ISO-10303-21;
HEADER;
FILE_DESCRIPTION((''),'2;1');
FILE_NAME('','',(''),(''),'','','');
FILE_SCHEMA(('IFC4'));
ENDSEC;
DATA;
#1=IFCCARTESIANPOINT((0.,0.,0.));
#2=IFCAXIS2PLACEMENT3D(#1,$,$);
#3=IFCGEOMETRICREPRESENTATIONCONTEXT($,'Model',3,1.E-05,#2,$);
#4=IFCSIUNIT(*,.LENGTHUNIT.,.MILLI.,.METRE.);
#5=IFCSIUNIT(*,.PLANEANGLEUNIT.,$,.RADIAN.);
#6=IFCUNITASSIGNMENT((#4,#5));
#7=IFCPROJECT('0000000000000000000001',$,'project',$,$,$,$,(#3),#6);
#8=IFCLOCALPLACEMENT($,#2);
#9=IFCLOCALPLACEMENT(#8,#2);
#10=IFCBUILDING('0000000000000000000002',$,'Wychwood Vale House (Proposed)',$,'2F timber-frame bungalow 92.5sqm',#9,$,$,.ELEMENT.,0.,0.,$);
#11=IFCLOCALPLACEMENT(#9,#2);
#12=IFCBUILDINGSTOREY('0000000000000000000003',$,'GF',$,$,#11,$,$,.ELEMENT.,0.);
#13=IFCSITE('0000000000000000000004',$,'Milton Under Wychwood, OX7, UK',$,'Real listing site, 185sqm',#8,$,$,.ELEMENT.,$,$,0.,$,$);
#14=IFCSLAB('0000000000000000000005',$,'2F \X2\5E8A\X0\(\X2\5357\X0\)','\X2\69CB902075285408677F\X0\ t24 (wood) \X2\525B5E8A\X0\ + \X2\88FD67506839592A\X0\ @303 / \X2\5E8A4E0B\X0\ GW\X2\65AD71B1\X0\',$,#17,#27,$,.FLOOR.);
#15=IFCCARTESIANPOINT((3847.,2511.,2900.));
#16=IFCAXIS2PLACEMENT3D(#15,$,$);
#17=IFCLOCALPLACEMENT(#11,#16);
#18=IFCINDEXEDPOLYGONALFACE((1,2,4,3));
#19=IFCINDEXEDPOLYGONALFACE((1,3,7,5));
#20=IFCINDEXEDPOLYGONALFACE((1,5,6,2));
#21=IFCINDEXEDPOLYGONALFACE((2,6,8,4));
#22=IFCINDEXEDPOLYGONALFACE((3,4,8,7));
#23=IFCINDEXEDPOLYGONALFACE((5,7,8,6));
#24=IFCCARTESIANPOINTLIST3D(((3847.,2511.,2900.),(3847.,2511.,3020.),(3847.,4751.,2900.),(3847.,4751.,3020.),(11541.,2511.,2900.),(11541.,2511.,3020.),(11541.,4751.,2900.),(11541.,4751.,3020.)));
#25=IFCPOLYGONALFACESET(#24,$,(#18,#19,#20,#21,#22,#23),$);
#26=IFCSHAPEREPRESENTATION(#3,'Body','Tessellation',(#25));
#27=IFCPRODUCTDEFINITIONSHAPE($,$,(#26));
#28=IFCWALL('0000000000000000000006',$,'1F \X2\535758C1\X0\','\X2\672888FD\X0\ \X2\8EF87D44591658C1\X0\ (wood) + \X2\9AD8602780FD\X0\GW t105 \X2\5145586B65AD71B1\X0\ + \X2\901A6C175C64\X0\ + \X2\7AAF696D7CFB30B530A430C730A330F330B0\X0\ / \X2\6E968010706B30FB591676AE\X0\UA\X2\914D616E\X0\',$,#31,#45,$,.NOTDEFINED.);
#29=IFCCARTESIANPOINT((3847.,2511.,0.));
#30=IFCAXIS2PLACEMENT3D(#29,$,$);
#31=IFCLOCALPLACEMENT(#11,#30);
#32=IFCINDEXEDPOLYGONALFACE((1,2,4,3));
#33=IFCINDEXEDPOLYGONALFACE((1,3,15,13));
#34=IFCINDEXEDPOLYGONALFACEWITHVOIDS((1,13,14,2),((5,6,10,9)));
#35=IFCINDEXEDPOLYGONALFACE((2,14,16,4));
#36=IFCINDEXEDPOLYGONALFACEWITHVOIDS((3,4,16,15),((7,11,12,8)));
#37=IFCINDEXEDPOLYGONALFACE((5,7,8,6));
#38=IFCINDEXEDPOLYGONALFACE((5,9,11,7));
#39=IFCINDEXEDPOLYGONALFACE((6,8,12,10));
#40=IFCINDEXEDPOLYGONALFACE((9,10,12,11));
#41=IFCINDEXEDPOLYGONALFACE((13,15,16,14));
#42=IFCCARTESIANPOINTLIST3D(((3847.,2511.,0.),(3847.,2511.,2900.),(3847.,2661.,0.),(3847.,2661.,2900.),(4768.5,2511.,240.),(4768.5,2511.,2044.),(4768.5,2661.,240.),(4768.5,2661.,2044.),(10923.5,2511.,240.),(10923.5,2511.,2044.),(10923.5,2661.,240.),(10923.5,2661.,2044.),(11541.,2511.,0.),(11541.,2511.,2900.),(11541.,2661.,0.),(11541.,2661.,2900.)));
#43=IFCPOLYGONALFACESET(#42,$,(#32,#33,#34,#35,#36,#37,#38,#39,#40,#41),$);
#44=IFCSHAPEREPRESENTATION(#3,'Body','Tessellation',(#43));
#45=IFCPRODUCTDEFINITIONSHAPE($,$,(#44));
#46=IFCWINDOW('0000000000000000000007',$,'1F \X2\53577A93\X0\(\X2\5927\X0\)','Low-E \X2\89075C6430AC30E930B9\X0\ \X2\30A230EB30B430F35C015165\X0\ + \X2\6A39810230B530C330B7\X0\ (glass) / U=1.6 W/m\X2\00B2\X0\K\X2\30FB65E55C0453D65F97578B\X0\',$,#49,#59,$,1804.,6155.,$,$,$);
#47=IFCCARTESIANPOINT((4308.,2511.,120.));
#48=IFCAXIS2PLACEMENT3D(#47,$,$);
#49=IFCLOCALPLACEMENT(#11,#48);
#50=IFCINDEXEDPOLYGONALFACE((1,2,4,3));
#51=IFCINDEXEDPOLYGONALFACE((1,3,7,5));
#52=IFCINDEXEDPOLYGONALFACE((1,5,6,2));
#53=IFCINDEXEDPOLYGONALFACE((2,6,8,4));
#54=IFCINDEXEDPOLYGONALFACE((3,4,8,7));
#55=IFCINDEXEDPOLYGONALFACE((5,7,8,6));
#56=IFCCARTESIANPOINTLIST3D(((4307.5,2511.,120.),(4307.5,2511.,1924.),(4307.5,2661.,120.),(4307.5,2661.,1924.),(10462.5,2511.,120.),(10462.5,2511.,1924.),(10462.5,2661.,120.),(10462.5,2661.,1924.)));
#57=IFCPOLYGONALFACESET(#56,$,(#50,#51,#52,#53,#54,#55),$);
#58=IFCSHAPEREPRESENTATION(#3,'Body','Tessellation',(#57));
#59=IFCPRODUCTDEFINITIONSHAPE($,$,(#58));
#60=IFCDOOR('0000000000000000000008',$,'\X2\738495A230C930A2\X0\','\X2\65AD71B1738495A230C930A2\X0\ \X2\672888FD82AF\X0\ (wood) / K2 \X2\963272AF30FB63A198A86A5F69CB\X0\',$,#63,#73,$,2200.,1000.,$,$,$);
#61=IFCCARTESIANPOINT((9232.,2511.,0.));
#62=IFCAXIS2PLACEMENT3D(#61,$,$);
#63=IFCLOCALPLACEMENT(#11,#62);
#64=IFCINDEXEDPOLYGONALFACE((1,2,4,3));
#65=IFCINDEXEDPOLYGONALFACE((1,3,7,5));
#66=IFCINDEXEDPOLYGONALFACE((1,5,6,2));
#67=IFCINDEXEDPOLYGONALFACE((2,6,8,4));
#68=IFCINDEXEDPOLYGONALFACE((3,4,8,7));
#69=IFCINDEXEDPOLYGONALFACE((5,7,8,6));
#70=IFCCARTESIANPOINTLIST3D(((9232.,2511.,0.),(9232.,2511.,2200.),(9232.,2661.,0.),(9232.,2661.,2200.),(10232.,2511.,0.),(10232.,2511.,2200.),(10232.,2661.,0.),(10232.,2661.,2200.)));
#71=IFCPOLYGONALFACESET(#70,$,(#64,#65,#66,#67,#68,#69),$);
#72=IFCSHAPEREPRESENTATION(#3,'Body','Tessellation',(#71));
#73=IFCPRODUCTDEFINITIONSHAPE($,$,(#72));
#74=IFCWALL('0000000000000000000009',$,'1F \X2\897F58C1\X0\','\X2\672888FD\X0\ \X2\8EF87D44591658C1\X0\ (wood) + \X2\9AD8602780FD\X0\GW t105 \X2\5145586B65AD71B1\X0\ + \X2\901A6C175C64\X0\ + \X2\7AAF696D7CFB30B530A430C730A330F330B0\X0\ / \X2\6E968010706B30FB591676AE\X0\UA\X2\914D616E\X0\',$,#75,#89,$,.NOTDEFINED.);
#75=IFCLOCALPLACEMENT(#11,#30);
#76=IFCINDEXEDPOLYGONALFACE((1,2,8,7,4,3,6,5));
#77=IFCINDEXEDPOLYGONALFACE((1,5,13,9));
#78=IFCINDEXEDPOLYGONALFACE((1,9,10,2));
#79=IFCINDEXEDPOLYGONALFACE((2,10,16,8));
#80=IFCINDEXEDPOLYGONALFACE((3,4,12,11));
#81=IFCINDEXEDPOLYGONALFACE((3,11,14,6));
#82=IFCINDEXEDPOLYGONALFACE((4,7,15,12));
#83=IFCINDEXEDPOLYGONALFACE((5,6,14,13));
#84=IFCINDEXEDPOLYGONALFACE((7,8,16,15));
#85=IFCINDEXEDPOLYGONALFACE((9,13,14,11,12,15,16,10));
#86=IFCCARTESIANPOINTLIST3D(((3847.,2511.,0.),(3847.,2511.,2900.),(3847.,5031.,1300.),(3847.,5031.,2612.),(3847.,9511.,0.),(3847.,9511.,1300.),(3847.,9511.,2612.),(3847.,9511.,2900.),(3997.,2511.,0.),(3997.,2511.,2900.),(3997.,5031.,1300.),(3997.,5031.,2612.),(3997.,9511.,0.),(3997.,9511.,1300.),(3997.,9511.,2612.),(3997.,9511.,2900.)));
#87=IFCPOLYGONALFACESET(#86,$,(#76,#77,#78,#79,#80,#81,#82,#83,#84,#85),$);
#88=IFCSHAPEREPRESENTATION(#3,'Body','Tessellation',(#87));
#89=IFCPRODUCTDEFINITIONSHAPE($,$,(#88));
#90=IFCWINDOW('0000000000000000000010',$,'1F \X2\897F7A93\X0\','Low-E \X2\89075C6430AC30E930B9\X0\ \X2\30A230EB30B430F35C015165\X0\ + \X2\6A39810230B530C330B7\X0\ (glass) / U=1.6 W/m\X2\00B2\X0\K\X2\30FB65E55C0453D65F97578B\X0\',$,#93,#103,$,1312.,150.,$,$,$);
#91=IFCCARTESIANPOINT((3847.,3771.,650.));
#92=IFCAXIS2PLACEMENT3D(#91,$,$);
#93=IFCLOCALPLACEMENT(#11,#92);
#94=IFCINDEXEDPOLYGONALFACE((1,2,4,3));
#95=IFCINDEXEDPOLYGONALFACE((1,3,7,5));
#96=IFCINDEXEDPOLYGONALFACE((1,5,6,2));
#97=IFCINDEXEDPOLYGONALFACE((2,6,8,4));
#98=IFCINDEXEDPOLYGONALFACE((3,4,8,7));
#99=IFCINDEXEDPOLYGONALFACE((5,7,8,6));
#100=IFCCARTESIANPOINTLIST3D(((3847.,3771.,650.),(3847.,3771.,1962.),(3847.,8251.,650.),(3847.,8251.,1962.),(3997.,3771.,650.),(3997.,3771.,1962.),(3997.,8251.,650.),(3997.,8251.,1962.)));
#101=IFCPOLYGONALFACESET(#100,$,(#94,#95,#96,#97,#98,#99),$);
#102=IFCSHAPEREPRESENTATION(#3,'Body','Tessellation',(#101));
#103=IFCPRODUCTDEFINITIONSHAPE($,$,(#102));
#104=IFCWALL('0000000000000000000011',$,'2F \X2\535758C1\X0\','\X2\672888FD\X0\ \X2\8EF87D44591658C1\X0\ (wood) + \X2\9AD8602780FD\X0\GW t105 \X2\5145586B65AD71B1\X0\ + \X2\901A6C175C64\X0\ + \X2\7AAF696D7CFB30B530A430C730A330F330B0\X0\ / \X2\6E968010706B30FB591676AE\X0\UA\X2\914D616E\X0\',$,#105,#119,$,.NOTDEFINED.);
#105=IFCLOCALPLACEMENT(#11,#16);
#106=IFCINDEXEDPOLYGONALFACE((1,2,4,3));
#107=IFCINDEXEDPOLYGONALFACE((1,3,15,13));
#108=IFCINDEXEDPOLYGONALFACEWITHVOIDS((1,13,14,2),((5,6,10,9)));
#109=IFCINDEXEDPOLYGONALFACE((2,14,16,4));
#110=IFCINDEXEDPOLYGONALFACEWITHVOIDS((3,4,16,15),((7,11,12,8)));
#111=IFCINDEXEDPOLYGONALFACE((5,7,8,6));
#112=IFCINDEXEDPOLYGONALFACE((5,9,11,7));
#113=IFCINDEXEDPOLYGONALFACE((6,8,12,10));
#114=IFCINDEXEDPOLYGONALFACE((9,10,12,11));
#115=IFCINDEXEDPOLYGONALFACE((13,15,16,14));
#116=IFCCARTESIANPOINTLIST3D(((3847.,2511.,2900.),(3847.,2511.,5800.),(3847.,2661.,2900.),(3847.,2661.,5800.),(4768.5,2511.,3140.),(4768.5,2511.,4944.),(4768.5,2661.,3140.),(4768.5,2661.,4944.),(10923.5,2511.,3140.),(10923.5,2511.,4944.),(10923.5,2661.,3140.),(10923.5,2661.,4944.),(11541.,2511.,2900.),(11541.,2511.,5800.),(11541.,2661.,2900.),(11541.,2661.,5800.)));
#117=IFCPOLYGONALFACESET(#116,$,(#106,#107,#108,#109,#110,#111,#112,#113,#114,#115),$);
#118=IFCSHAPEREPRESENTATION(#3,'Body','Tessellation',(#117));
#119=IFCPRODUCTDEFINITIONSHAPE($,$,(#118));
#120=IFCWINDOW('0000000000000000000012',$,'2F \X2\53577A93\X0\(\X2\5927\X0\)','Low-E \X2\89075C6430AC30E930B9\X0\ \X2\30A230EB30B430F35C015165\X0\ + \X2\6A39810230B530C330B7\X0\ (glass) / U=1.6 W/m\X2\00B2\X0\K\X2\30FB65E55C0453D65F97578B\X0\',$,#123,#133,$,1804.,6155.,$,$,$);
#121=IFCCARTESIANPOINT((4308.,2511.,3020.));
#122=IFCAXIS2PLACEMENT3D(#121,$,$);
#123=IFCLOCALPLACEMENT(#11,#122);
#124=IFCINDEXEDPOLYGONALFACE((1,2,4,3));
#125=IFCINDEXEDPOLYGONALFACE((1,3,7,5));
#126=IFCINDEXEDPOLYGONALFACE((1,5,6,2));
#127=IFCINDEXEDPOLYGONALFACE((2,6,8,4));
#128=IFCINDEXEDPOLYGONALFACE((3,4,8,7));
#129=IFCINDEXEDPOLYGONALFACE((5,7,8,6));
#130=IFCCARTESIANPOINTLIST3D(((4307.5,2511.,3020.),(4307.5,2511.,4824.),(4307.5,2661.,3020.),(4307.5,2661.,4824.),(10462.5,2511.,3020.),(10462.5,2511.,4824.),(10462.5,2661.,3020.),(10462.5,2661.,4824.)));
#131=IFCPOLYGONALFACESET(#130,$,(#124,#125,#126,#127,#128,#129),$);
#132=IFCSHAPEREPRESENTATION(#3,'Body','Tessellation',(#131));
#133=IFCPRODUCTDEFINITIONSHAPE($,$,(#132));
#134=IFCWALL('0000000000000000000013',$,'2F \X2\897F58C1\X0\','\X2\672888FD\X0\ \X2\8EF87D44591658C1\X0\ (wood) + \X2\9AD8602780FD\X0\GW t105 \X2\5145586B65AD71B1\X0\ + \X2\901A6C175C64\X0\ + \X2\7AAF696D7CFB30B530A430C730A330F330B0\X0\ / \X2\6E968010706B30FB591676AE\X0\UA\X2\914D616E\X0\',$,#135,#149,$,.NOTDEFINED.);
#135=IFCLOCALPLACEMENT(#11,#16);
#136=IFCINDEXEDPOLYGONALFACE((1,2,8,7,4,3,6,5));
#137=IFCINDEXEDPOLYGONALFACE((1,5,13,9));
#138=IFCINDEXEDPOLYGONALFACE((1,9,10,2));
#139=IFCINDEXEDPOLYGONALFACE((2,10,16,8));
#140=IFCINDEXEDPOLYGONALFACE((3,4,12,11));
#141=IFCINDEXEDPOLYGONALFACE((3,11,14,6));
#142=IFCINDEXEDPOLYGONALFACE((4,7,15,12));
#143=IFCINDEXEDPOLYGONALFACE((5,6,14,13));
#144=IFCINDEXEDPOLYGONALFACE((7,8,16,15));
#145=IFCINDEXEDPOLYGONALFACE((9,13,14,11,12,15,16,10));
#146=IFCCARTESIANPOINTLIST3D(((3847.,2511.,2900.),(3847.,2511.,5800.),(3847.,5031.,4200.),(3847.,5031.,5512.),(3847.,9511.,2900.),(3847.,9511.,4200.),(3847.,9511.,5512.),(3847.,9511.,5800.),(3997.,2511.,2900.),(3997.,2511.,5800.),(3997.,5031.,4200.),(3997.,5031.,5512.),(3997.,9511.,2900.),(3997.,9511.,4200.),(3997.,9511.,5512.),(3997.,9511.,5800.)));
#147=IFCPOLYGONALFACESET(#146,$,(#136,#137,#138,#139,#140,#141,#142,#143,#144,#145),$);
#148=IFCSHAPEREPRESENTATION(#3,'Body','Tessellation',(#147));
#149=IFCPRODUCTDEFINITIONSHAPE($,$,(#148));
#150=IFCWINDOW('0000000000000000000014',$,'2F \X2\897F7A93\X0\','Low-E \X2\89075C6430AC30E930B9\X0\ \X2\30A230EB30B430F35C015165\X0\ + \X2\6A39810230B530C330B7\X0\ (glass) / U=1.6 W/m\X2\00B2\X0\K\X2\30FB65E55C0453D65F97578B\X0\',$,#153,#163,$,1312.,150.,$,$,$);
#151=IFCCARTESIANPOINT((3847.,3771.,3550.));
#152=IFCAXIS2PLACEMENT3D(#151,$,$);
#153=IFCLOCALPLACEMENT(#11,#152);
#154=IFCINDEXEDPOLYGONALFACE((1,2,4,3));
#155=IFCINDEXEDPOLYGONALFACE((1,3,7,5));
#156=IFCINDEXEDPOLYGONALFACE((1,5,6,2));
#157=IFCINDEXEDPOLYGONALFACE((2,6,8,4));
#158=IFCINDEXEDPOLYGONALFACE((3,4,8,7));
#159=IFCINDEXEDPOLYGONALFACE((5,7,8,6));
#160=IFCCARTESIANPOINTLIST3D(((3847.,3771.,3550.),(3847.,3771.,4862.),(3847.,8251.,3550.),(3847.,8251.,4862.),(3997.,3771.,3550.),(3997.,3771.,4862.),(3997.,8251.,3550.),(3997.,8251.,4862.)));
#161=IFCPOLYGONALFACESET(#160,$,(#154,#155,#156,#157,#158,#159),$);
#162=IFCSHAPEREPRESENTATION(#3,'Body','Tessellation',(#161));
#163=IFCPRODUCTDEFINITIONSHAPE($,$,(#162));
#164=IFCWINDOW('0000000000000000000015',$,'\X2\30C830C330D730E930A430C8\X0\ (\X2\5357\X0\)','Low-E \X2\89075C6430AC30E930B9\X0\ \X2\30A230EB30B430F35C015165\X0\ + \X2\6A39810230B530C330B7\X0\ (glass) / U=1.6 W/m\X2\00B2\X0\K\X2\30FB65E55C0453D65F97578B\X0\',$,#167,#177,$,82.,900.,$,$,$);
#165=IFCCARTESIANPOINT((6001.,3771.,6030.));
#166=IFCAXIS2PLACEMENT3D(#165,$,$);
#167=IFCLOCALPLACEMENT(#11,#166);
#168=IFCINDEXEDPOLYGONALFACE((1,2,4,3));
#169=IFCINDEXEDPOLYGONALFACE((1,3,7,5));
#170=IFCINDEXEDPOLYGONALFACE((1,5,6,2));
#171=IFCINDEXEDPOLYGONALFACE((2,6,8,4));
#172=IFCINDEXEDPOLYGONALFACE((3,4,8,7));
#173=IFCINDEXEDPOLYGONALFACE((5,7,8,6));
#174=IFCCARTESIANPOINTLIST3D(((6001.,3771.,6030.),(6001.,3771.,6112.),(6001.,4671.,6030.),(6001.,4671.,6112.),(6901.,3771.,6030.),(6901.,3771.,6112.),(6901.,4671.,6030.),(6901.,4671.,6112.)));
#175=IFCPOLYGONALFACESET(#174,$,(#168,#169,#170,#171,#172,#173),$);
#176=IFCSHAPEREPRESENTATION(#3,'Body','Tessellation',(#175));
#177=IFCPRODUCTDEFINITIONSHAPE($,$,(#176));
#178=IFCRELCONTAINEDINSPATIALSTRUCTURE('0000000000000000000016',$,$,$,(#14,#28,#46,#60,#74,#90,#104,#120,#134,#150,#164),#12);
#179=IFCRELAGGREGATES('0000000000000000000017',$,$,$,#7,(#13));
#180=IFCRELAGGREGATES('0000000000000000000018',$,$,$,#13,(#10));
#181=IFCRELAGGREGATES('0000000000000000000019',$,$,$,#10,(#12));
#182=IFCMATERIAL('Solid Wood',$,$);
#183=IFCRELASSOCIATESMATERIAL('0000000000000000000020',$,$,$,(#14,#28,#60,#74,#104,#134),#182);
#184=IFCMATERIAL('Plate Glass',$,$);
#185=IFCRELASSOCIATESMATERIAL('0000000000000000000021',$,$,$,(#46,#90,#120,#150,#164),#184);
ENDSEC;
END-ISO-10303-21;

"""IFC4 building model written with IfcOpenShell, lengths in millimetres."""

from ifc_helpers import new_model, si_unit, frame, frame_2d, origin, place, context, project, spatial, rectangle, extrude, material, element, fill, save


model = new_model("IFC4")

# Units and contexts
model_context = context("Model", 3, precision=1e-05, world=origin())
ifc_project = project(units=[si_unit("LENGTHUNIT", "METRE", prefix="MILLI"), si_unit("PLANEANGLEUNIT", "RADIAN")], contexts=[model_context])

# Site, building, storey
site_placement = place(None, origin())
site = spatial("IfcSite", under=ifc_project, at=site_placement, Name="Milton Under Wychwood, OX7, UK", ObjectType="Real listing site, 185sqm", CompositionType="ELEMENT", RefElevation=0.0)
building_placement = place(site_placement, origin())
building = spatial("IfcBuilding", under=site, at=building_placement, Name="Wychwood Vale House (Proposed)", ObjectType="2F timber-frame bungalow 92.5sqm", CompositionType="ELEMENT", ElevationOfRefHeight=0.0, ElevationOfTerrain=0.0)
storey_placement = place(building_placement, origin())
storey = spatial("IfcBuildingStorey", under=building, at=storey_placement, Name="GF", CompositionType="ELEMENT", Elevation=0.0)

# Slab
ifc_material_1 = material(Name="Solid Wood")
slab_1_placement = place(storey_placement, frame((3847.0, 2511.0, 2900.0)))
element("IfcSlab", 1, at=slab_1_placement, inside=storey, material=ifc_material_1, Name="2F 床(南)", Description="構造用合板 t24 (wood) 剛床 + 製材根太 @303 / 床下 GW断熱", PredefinedType="FLOOR", context=model_context, shape_type="SweptSolid", body=[
    extrude(rectangle(XDim=7694.0, YDim=2240.0, at=frame_2d((3847.0, 1120.0))), frame((3847.0, 2511.0, 2900.0)), (0.0, 0.0, 1.0), 120.0),
])

# Wall, openings, window, door
wall_1_placement = place(storey_placement, frame((3847.0, 2511.0, 0.0)))
wall_1 = element("IfcWall", 2, at=wall_1_placement, inside=storey, material=ifc_material_1, Name="1F 南壁", Description="木製 軸組外壁 (wood) + 高性能GW t105 充填断熱 + 通気層 + 窯業系サイディング / 準耐火・外皮UA配慮", PredefinedType="NOTDEFINED", context=model_context, shape_type="SweptSolid", body=[
    extrude(rectangle(XDim=7694.0, YDim=150.0, at=frame_2d((3847.0, 75.0))), frame((3847.0, 2511.0, 0.0)), (0.0, 0.0, 1.0), 2900.0),
])
opening_1_placement = place(storey_placement, frame((4308.0, 2511.0, 120.0)))
opening_1 = element("IfcOpeningElement", 3, at=opening_1_placement, cuts=wall_1, PredefinedType="NOTDEFINED", context=model_context, shape_type="SweptSolid", body=[
    extrude(rectangle(XDim=6155.0, YDim=150.0, at=frame_2d((3077.0, 75.0))), frame((4308.0, 2511.0, 120.0)), (0.0, 0.0, 1.0), 1804.0),
])
opening_2_placement = place(storey_placement, frame((9232.0, 2511.0, 0.0)))
opening_2 = element("IfcOpeningElement", 4, at=opening_2_placement, cuts=wall_1, PredefinedType="NOTDEFINED", context=model_context, shape_type="SweptSolid", body=[
    extrude(rectangle(XDim=1000.0, YDim=150.0, at=frame_2d((500.0, 75.0))), frame((9232.0, 2511.0, 0.0)), (0.0, 0.0, 1.0), 2200.0),
])
ifc_material_2 = material(Name="Plate Glass")
window_1_placement = place(storey_placement, frame((4308.0, 2511.0, 120.0)))
window_1 = element("IfcWindow", 5, at=window_1_placement, inside=storey, material=ifc_material_2, Name="1F 南窓(大)", Description="Low-E 複層ガラス アルゴン封入 + 樹脂サッシ (glass) / U=1.6 W/m²K・日射取得型", OverallHeight=1804.0, OverallWidth=6155.0, context=model_context, shape_type="SweptSolid", body=[
    extrude(rectangle(XDim=6155.0, YDim=150.0, at=frame_2d((3077.0, 75.0))), frame((4308.0, 2511.0, 120.0)), (0.0, 0.0, 1.0), 1804.0),
])
fill(opening_1, window_1)
door_placement = place(storey_placement, frame((9232.0, 2511.0, 0.0)))
door = element("IfcDoor", 6, at=door_placement, inside=storey, material=ifc_material_1, Name="玄関ドア", Description="断熱玄関ドア 木製芯 (wood) / K2 防犯・採風機構", OverallHeight=2200.0, OverallWidth=1000.0, context=model_context, shape_type="SweptSolid", body=[
    extrude(rectangle(XDim=1000.0, YDim=150.0, at=frame_2d((500.0, 75.0))), frame((9232.0, 2511.0, 0.0)), (0.0, 0.0, 1.0), 2200.0),
])
fill(opening_2, door)

# Walls, openings, windows
wall_2_placement = place(storey_placement, frame((3847.0, 2511.0, 0.0)))
wall_2 = element("IfcWall", 7, at=wall_2_placement, inside=storey, material=ifc_material_1, Name="1F 西壁", Description="木製 軸組外壁 (wood) + 高性能GW t105 充填断熱 + 通気層 + 窯業系サイディング / 準耐火・外皮UA配慮", PredefinedType="NOTDEFINED", context=model_context, shape_type="SweptSolid", body=[
    extrude(rectangle(XDim=150.0, YDim=7000.0, at=frame_2d((75.0, 3500.0))), frame((3847.0, 2511.0, 0.0)), (0.0, 0.0, 1.0), 2900.0),
])
opening_3_placement = place(storey_placement, frame((3847.0, 3771.0, 650.0)))
opening_3 = element("IfcOpeningElement", 8, at=opening_3_placement, cuts=wall_2, PredefinedType="NOTDEFINED", context=model_context, shape_type="SweptSolid", body=[
    extrude(rectangle(XDim=150.0, YDim=4480.0, at=frame_2d((75.0, 2240.0))), frame((3847.0, 3771.0, 650.0)), (0.0, 0.0, 1.0), 1312.0),
])
window_2_placement = place(storey_placement, frame((3847.0, 3771.0, 650.0)))
window_2 = element("IfcWindow", 9, at=window_2_placement, inside=storey, material=ifc_material_2, Name="1F 西窓", Description="Low-E 複層ガラス アルゴン封入 + 樹脂サッシ (glass) / U=1.6 W/m²K・日射取得型", OverallHeight=1312.0, OverallWidth=150.0, context=model_context, shape_type="SweptSolid", body=[
    extrude(rectangle(XDim=150.0, YDim=4480.0, at=frame_2d((75.0, 2240.0))), frame((3847.0, 3771.0, 650.0)), (0.0, 0.0, 1.0), 1312.0),
])
fill(opening_3, window_2)
wall_3_placement = place(storey_placement, frame((3847.0, 2511.0, 2900.0)))
wall_3 = element("IfcWall", 10, at=wall_3_placement, inside=storey, material=ifc_material_1, Name="2F 南壁", Description="木製 軸組外壁 (wood) + 高性能GW t105 充填断熱 + 通気層 + 窯業系サイディング / 準耐火・外皮UA配慮", PredefinedType="NOTDEFINED", context=model_context, shape_type="SweptSolid", body=[
    extrude(rectangle(XDim=7694.0, YDim=150.0, at=frame_2d((3847.0, 75.0))), frame((3847.0, 2511.0, 2900.0)), (0.0, 0.0, 1.0), 2900.0),
])
opening_4_placement = place(storey_placement, frame((4308.0, 2511.0, 3020.0)))
opening_4 = element("IfcOpeningElement", 11, at=opening_4_placement, cuts=wall_3, PredefinedType="NOTDEFINED", context=model_context, shape_type="SweptSolid", body=[
    extrude(rectangle(XDim=6155.0, YDim=150.0, at=frame_2d((3077.0, 75.0))), frame((4308.0, 2511.0, 3020.0)), (0.0, 0.0, 1.0), 1804.0),
])
window_3_placement = place(storey_placement, frame((4308.0, 2511.0, 3020.0)))
window_3 = element("IfcWindow", 12, at=window_3_placement, inside=storey, material=ifc_material_2, Name="2F 南窓(大)", Description="Low-E 複層ガラス アルゴン封入 + 樹脂サッシ (glass) / U=1.6 W/m²K・日射取得型", OverallHeight=1804.0, OverallWidth=6155.0, context=model_context, shape_type="SweptSolid", body=[
    extrude(rectangle(XDim=6155.0, YDim=150.0, at=frame_2d((3077.0, 75.0))), frame((4308.0, 2511.0, 3020.0)), (0.0, 0.0, 1.0), 1804.0),
])
fill(opening_4, window_3)
wall_4_placement = place(storey_placement, frame((3847.0, 2511.0, 2900.0)))
wall_4 = element("IfcWall", 13, at=wall_4_placement, inside=storey, material=ifc_material_1, Name="2F 西壁", Description="木製 軸組外壁 (wood) + 高性能GW t105 充填断熱 + 通気層 + 窯業系サイディング / 準耐火・外皮UA配慮", PredefinedType="NOTDEFINED", context=model_context, shape_type="SweptSolid", body=[
    extrude(rectangle(XDim=150.0, YDim=7000.0, at=frame_2d((75.0, 3500.0))), frame((3847.0, 2511.0, 2900.0)), (0.0, 0.0, 1.0), 2900.0),
])
opening_5_placement = place(storey_placement, frame((3847.0, 3771.0, 3550.0)))
opening_5 = element("IfcOpeningElement", 14, at=opening_5_placement, cuts=wall_4, PredefinedType="NOTDEFINED", context=model_context, shape_type="SweptSolid", body=[
    extrude(rectangle(XDim=150.0, YDim=4480.0, at=frame_2d((75.0, 2240.0))), frame((3847.0, 3771.0, 3550.0)), (0.0, 0.0, 1.0), 1312.0),
])
window_4_placement = place(storey_placement, frame((3847.0, 3771.0, 3550.0)))
window_4 = element("IfcWindow", 15, at=window_4_placement, inside=storey, material=ifc_material_2, Name="2F 西窓", Description="Low-E 複層ガラス アルゴン封入 + 樹脂サッシ (glass) / U=1.6 W/m²K・日射取得型", OverallHeight=1312.0, OverallWidth=150.0, context=model_context, shape_type="SweptSolid", body=[
    extrude(rectangle(XDim=150.0, YDim=4480.0, at=frame_2d((75.0, 2240.0))), frame((3847.0, 3771.0, 3550.0)), (0.0, 0.0, 1.0), 1312.0),
])
fill(opening_5, window_4)

# Window
window_5_placement = place(storey_placement, frame((6001.0, 3771.0, 6030.0)))
element("IfcWindow", 16, at=window_5_placement, inside=storey, material=ifc_material_2, Name="トップライト (南)", Description="Low-E 複層ガラス アルゴン封入 + 樹脂サッシ (glass) / U=1.6 W/m²K・日射取得型", OverallHeight=82.0, OverallWidth=900.0, context=model_context, shape_type="SweptSolid", body=[
    extrude(rectangle(XDim=900.0, YDim=900.0, at=frame_2d((450.0, 450.0))), frame((6001.0, 3771.0, 6030.0)), (0.0, 0.0, 1.0), 82.0),
])

save(model, "model.ifc")
